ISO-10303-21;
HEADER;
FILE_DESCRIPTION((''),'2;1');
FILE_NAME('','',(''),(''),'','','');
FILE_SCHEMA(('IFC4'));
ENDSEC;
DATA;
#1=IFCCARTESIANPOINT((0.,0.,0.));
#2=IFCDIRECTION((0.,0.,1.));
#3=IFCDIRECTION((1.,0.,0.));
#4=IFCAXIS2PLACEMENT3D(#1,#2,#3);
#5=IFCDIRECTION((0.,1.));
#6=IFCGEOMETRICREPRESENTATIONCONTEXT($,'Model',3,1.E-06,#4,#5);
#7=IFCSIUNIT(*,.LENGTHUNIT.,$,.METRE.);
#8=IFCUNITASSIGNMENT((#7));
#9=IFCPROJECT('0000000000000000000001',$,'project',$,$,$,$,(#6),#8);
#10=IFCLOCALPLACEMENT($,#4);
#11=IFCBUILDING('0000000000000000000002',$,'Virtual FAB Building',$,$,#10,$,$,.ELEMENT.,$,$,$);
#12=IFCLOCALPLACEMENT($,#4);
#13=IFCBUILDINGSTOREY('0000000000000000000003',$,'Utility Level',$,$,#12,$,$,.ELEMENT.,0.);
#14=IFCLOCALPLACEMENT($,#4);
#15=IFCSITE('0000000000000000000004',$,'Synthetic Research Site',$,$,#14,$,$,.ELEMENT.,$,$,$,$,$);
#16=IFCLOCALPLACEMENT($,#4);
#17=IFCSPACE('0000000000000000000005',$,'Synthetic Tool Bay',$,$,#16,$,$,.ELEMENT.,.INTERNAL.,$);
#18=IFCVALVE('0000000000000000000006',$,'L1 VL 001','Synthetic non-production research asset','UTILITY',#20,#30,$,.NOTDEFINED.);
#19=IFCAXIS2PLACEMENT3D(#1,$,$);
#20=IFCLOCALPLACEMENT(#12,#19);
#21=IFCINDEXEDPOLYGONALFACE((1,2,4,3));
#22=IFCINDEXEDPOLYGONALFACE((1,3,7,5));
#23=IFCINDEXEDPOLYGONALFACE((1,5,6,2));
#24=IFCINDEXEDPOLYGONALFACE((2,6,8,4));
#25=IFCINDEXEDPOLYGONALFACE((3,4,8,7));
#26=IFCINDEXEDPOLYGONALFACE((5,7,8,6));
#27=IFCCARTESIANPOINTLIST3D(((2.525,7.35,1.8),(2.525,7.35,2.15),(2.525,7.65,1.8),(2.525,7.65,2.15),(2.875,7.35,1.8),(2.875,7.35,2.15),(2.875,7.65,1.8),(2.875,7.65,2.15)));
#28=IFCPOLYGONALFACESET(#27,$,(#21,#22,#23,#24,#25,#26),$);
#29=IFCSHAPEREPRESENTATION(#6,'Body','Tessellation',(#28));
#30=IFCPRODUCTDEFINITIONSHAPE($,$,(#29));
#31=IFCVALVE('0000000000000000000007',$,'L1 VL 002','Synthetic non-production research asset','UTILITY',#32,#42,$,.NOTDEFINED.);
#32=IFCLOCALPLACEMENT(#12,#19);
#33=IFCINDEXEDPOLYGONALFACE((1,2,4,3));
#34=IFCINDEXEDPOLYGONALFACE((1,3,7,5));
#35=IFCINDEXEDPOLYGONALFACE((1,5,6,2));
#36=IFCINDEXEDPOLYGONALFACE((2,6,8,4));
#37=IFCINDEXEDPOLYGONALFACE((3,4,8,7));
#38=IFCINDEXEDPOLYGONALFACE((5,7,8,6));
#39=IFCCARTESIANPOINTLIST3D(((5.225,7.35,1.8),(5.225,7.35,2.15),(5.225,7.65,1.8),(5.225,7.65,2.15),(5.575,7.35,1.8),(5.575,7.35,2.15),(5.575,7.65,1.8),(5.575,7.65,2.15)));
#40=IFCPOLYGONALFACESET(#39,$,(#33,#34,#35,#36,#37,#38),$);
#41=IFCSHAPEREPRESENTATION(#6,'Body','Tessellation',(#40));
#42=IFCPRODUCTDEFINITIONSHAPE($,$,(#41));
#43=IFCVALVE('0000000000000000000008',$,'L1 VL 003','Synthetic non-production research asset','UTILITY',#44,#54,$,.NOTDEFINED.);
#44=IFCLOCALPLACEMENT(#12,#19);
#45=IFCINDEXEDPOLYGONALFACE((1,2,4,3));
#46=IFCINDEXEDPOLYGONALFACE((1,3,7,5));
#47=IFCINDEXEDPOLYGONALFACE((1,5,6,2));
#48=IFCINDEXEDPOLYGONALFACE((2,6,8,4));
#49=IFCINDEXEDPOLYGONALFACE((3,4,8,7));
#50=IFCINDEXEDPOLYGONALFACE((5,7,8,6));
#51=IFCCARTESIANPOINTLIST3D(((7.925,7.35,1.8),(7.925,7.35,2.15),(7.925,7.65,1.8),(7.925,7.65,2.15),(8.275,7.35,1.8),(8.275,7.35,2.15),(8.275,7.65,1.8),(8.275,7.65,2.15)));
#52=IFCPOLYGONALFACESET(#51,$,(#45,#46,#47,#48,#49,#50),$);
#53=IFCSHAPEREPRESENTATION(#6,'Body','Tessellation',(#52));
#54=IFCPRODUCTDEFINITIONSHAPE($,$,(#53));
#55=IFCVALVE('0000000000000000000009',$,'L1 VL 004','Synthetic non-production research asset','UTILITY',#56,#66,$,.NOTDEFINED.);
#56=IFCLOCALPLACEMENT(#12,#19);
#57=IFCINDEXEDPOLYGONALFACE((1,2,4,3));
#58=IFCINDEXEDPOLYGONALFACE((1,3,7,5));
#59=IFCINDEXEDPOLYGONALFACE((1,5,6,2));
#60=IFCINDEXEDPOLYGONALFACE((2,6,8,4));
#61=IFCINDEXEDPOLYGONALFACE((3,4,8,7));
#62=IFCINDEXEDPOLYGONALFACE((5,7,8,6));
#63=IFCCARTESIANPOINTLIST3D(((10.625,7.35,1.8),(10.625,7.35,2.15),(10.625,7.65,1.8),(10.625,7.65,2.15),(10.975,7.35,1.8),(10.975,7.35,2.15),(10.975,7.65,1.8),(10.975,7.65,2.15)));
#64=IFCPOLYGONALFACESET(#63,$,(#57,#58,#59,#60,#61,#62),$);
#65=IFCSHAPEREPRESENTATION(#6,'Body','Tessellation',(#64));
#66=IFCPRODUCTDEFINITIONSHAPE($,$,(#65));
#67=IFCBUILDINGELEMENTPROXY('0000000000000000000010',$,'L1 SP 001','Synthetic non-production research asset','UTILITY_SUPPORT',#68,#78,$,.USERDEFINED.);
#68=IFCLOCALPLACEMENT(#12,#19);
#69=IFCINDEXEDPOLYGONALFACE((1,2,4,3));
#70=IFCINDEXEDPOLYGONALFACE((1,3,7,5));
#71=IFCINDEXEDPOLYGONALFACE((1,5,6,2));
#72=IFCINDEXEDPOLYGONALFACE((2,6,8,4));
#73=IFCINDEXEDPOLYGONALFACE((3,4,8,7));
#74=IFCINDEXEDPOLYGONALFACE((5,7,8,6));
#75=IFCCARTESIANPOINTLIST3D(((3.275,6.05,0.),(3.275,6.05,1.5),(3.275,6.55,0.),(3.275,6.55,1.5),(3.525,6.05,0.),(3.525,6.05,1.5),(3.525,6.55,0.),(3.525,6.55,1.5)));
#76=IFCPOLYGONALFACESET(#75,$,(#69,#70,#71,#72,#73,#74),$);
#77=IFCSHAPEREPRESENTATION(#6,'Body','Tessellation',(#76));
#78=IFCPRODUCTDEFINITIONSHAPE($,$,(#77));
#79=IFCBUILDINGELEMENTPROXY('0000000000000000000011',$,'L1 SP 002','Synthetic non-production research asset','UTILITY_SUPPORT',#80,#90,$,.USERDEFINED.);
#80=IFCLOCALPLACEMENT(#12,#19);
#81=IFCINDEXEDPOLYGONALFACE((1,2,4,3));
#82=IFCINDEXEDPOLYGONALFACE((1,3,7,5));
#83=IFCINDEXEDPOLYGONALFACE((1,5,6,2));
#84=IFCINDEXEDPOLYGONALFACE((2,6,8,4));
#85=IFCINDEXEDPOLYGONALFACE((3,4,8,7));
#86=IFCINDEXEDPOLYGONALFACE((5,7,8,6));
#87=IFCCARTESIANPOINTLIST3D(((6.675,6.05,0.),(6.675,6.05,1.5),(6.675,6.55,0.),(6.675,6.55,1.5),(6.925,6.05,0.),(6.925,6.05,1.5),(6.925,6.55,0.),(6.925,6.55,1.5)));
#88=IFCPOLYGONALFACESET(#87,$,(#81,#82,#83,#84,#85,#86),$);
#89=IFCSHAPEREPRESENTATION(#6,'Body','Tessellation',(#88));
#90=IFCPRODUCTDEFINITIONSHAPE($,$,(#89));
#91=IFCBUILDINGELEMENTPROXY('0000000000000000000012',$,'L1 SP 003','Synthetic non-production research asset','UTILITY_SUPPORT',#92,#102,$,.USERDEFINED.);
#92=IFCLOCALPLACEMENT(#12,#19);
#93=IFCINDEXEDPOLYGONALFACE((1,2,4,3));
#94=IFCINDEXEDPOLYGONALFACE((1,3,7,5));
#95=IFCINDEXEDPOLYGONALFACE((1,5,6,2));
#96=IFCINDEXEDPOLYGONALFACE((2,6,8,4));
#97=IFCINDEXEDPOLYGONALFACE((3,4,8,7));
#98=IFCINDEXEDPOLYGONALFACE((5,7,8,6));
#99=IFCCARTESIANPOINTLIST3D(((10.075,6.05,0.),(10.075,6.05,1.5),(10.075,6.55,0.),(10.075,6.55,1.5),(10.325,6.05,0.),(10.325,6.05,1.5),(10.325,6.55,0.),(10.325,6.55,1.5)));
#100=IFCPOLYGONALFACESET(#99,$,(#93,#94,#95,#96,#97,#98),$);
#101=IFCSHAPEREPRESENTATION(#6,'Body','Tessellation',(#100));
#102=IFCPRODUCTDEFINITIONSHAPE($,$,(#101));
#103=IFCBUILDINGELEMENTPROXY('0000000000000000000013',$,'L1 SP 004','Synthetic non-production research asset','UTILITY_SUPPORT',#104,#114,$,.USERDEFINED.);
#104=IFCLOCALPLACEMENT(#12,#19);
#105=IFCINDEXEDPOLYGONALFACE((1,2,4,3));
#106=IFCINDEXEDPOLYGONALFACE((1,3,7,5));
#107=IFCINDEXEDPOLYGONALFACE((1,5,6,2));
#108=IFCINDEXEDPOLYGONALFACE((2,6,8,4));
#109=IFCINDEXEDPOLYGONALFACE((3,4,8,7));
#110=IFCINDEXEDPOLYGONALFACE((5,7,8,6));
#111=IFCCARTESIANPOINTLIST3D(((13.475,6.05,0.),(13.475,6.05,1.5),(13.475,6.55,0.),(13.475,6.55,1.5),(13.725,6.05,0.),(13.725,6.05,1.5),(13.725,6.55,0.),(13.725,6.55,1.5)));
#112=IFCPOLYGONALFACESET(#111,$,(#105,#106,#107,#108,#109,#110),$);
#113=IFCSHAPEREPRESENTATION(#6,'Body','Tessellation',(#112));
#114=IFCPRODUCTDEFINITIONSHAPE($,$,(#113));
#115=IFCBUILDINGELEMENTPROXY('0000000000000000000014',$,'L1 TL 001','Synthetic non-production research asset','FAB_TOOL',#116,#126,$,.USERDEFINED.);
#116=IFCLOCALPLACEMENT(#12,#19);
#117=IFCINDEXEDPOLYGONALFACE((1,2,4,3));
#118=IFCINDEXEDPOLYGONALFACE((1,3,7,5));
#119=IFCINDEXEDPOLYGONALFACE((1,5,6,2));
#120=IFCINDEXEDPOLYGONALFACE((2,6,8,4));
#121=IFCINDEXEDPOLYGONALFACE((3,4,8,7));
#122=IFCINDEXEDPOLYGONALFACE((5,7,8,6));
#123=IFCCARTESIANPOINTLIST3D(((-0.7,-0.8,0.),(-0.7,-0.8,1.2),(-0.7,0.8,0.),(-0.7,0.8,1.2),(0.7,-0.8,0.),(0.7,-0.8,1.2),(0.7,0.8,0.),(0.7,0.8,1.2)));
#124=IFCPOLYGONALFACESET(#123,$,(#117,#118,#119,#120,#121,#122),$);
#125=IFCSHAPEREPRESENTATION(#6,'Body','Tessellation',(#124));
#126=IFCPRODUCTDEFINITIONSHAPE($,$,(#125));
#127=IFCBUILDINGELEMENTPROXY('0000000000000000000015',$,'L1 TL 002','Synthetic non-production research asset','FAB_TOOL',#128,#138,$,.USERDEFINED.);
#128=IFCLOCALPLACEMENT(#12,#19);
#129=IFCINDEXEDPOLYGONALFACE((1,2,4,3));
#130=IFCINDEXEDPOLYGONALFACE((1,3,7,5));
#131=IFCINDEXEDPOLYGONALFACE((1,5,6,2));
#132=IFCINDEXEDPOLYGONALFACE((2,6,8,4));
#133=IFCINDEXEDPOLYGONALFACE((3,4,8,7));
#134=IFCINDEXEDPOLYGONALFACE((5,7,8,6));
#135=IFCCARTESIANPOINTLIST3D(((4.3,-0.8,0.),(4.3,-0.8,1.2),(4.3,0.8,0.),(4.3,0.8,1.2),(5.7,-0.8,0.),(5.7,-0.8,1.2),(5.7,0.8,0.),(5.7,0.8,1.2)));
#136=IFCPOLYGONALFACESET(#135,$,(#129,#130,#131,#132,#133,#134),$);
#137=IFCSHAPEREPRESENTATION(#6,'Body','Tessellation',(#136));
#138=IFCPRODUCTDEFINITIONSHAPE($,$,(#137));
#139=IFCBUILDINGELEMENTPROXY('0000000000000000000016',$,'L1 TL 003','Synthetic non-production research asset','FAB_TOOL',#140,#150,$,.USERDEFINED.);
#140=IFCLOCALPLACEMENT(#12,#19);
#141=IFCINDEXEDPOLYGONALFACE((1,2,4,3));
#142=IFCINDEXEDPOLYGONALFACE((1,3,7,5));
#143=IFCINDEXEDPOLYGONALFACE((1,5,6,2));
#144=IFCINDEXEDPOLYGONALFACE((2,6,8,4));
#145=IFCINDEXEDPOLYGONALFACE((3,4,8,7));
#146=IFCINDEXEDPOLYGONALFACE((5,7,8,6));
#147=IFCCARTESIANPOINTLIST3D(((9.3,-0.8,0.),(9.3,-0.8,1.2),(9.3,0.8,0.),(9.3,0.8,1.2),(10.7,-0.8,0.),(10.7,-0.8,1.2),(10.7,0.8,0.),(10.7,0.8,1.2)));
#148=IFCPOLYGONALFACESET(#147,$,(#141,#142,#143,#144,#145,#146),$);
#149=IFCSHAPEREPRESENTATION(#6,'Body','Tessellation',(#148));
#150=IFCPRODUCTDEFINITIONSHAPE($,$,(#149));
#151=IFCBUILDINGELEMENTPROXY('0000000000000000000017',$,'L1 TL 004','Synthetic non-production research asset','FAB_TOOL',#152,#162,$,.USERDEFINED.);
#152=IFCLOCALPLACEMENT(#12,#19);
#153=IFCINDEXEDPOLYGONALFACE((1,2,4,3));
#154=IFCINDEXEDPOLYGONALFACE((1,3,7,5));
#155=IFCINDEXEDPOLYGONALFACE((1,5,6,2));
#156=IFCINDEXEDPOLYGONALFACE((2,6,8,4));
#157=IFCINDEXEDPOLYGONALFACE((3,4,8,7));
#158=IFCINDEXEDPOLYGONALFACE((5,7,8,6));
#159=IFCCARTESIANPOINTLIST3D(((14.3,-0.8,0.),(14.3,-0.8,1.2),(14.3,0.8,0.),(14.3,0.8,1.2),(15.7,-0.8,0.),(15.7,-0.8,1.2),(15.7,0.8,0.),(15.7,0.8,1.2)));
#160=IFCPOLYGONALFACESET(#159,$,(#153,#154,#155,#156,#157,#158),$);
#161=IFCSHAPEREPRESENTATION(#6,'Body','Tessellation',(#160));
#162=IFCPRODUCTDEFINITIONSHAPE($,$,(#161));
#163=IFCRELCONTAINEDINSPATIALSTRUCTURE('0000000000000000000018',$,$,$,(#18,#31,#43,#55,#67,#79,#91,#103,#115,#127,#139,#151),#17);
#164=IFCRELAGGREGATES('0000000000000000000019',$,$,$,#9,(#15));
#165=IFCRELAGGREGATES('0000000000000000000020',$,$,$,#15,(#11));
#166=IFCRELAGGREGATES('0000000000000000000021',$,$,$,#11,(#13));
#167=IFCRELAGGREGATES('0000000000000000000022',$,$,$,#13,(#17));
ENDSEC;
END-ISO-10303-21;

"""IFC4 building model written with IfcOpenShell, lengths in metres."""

from ifc_helpers import new_model, si_unit, direction, frame, origin_with_axes, origin_2d_with_axis, place, context, project, spatial, rectangle, extrude, element, save


model = new_model("IFC4")

# Units and contexts
model_context = context("Model", 3, precision=1e-06, world=origin_with_axes(), true_north=direction((0.0, 1.0)))
ifc_project = project(units=[si_unit("LENGTHUNIT", "METRE")], contexts=[model_context])

# Site, building, storey, space
site_placement = place(None, origin_with_axes())
site = spatial("IfcSite", under=ifc_project, at=site_placement, Name="Synthetic Research Site", CompositionType="ELEMENT")
building_placement = place(None, origin_with_axes())
building = spatial("IfcBuilding", under=site, at=building_placement, Name="Virtual FAB Building", CompositionType="ELEMENT")
storey_placement = place(None, origin_with_axes())
storey = spatial("IfcBuildingStorey", under=building, at=storey_placement, Name="Utility Level", CompositionType="ELEMENT", Elevation=0.0)
space_placement = place(None, origin_with_axes())
space = spatial("IfcSpace", under=storey, at=space_placement, Name="Synthetic Tool Bay", CompositionType="ELEMENT", PredefinedType="INTERNAL")

# Valves
for number, where, z_axis, x_axis, name in (
    (1, (2.7, 7.5, 1.8), (0.0, 0.0, 1.0), (1.0, 0.0, 0.0), "L1 VL 001"),
    (2, (5.4, 7.5, 1.8), (0.0, 0.0, 1.0), (1.0, 0.0, 0.0), "L1 VL 002"),
    (3, (8.1, 7.5, 1.8), (0.0, 0.0, 1.0), (1.0, 0.0, 0.0), "L1 VL 003"),
    (4, (10.8, 7.5, 1.8), (0.0, 0.0, 1.0), (1.0, 0.0, 0.0), "L1 VL 004"),
):
    element("IfcValve", number, at=place(None, frame(where, z_axis=z_axis, x_axis=x_axis)), inside=space, Name=name, Description="Synthetic non-production research asset", ObjectType="UTILITY", PredefinedType="NOTDEFINED", context=model_context, shape_type="SweptSolid", body=[
        extrude(rectangle(XDim=0.35, YDim=0.3, at=origin_2d_with_axis()), origin_with_axes(), (0.0, 0.0, 1.0), 0.35),
    ])

# Building element proxies
for number, where, z_axis, x_axis, name in (
    (5, (3.4, 6.3, 0.0), (0.0, 0.0, 1.0), (1.0, 0.0, 0.0), "L1 SP 001"),
    (6, (6.8, 6.3, 0.0), (0.0, 0.0, 1.0), (1.0, 0.0, 0.0), "L1 SP 002"),
    (7, (10.2, 6.3, 0.0), (0.0, 0.0, 1.0), (1.0, 0.0, 0.0), "L1 SP 003"),
    (8, (13.6, 6.3, 0.0), (0.0, 0.0, 1.0), (1.0, 0.0, 0.0), "L1 SP 004"),
):
    element("IfcBuildingElementProxy", number, at=place(None, frame(where, z_axis=z_axis, x_axis=x_axis)), inside=space, Name=name, Description="Synthetic non-production research asset", ObjectType="UTILITY_SUPPORT", PredefinedType="USERDEFINED", context=model_context, shape_type="SweptSolid", body=[
        extrude(rectangle(XDim=0.25, YDim=0.5, at=origin_2d_with_axis()), origin_with_axes(), (0.0, 0.0, 1.0), 1.5),
    ])
for number, where, z_axis, x_axis, name in (
    (9, (0.0, 0.0, 0.0), (0.0, 0.0, 1.0), (1.0, 0.0, 0.0), "L1 TL 001"),
    (10, (5.0, 0.0, 0.0), (0.0, 0.0, 1.0), (1.0, 0.0, 0.0), "L1 TL 002"),
    (11, (10.0, 0.0, 0.0), (0.0, 0.0, 1.0), (1.0, 0.0, 0.0), "L1 TL 003"),
    (12, (15.0, 0.0, 0.0), (0.0, 0.0, 1.0), (1.0, 0.0, 0.0), "L1 TL 004"),
):
    element("IfcBuildingElementProxy", number, at=place(None, frame(where, z_axis=z_axis, x_axis=x_axis)), inside=space, Name=name, Description="Synthetic non-production research asset", ObjectType="FAB_TOOL", PredefinedType="USERDEFINED", context=model_context, shape_type="SweptSolid", body=[
        extrude(rectangle(XDim=1.4, YDim=1.6, at=origin_2d_with_axis()), origin_with_axes(), (0.0, 0.0, 1.0), 1.2),
    ])

save(model, "model.ifc")
